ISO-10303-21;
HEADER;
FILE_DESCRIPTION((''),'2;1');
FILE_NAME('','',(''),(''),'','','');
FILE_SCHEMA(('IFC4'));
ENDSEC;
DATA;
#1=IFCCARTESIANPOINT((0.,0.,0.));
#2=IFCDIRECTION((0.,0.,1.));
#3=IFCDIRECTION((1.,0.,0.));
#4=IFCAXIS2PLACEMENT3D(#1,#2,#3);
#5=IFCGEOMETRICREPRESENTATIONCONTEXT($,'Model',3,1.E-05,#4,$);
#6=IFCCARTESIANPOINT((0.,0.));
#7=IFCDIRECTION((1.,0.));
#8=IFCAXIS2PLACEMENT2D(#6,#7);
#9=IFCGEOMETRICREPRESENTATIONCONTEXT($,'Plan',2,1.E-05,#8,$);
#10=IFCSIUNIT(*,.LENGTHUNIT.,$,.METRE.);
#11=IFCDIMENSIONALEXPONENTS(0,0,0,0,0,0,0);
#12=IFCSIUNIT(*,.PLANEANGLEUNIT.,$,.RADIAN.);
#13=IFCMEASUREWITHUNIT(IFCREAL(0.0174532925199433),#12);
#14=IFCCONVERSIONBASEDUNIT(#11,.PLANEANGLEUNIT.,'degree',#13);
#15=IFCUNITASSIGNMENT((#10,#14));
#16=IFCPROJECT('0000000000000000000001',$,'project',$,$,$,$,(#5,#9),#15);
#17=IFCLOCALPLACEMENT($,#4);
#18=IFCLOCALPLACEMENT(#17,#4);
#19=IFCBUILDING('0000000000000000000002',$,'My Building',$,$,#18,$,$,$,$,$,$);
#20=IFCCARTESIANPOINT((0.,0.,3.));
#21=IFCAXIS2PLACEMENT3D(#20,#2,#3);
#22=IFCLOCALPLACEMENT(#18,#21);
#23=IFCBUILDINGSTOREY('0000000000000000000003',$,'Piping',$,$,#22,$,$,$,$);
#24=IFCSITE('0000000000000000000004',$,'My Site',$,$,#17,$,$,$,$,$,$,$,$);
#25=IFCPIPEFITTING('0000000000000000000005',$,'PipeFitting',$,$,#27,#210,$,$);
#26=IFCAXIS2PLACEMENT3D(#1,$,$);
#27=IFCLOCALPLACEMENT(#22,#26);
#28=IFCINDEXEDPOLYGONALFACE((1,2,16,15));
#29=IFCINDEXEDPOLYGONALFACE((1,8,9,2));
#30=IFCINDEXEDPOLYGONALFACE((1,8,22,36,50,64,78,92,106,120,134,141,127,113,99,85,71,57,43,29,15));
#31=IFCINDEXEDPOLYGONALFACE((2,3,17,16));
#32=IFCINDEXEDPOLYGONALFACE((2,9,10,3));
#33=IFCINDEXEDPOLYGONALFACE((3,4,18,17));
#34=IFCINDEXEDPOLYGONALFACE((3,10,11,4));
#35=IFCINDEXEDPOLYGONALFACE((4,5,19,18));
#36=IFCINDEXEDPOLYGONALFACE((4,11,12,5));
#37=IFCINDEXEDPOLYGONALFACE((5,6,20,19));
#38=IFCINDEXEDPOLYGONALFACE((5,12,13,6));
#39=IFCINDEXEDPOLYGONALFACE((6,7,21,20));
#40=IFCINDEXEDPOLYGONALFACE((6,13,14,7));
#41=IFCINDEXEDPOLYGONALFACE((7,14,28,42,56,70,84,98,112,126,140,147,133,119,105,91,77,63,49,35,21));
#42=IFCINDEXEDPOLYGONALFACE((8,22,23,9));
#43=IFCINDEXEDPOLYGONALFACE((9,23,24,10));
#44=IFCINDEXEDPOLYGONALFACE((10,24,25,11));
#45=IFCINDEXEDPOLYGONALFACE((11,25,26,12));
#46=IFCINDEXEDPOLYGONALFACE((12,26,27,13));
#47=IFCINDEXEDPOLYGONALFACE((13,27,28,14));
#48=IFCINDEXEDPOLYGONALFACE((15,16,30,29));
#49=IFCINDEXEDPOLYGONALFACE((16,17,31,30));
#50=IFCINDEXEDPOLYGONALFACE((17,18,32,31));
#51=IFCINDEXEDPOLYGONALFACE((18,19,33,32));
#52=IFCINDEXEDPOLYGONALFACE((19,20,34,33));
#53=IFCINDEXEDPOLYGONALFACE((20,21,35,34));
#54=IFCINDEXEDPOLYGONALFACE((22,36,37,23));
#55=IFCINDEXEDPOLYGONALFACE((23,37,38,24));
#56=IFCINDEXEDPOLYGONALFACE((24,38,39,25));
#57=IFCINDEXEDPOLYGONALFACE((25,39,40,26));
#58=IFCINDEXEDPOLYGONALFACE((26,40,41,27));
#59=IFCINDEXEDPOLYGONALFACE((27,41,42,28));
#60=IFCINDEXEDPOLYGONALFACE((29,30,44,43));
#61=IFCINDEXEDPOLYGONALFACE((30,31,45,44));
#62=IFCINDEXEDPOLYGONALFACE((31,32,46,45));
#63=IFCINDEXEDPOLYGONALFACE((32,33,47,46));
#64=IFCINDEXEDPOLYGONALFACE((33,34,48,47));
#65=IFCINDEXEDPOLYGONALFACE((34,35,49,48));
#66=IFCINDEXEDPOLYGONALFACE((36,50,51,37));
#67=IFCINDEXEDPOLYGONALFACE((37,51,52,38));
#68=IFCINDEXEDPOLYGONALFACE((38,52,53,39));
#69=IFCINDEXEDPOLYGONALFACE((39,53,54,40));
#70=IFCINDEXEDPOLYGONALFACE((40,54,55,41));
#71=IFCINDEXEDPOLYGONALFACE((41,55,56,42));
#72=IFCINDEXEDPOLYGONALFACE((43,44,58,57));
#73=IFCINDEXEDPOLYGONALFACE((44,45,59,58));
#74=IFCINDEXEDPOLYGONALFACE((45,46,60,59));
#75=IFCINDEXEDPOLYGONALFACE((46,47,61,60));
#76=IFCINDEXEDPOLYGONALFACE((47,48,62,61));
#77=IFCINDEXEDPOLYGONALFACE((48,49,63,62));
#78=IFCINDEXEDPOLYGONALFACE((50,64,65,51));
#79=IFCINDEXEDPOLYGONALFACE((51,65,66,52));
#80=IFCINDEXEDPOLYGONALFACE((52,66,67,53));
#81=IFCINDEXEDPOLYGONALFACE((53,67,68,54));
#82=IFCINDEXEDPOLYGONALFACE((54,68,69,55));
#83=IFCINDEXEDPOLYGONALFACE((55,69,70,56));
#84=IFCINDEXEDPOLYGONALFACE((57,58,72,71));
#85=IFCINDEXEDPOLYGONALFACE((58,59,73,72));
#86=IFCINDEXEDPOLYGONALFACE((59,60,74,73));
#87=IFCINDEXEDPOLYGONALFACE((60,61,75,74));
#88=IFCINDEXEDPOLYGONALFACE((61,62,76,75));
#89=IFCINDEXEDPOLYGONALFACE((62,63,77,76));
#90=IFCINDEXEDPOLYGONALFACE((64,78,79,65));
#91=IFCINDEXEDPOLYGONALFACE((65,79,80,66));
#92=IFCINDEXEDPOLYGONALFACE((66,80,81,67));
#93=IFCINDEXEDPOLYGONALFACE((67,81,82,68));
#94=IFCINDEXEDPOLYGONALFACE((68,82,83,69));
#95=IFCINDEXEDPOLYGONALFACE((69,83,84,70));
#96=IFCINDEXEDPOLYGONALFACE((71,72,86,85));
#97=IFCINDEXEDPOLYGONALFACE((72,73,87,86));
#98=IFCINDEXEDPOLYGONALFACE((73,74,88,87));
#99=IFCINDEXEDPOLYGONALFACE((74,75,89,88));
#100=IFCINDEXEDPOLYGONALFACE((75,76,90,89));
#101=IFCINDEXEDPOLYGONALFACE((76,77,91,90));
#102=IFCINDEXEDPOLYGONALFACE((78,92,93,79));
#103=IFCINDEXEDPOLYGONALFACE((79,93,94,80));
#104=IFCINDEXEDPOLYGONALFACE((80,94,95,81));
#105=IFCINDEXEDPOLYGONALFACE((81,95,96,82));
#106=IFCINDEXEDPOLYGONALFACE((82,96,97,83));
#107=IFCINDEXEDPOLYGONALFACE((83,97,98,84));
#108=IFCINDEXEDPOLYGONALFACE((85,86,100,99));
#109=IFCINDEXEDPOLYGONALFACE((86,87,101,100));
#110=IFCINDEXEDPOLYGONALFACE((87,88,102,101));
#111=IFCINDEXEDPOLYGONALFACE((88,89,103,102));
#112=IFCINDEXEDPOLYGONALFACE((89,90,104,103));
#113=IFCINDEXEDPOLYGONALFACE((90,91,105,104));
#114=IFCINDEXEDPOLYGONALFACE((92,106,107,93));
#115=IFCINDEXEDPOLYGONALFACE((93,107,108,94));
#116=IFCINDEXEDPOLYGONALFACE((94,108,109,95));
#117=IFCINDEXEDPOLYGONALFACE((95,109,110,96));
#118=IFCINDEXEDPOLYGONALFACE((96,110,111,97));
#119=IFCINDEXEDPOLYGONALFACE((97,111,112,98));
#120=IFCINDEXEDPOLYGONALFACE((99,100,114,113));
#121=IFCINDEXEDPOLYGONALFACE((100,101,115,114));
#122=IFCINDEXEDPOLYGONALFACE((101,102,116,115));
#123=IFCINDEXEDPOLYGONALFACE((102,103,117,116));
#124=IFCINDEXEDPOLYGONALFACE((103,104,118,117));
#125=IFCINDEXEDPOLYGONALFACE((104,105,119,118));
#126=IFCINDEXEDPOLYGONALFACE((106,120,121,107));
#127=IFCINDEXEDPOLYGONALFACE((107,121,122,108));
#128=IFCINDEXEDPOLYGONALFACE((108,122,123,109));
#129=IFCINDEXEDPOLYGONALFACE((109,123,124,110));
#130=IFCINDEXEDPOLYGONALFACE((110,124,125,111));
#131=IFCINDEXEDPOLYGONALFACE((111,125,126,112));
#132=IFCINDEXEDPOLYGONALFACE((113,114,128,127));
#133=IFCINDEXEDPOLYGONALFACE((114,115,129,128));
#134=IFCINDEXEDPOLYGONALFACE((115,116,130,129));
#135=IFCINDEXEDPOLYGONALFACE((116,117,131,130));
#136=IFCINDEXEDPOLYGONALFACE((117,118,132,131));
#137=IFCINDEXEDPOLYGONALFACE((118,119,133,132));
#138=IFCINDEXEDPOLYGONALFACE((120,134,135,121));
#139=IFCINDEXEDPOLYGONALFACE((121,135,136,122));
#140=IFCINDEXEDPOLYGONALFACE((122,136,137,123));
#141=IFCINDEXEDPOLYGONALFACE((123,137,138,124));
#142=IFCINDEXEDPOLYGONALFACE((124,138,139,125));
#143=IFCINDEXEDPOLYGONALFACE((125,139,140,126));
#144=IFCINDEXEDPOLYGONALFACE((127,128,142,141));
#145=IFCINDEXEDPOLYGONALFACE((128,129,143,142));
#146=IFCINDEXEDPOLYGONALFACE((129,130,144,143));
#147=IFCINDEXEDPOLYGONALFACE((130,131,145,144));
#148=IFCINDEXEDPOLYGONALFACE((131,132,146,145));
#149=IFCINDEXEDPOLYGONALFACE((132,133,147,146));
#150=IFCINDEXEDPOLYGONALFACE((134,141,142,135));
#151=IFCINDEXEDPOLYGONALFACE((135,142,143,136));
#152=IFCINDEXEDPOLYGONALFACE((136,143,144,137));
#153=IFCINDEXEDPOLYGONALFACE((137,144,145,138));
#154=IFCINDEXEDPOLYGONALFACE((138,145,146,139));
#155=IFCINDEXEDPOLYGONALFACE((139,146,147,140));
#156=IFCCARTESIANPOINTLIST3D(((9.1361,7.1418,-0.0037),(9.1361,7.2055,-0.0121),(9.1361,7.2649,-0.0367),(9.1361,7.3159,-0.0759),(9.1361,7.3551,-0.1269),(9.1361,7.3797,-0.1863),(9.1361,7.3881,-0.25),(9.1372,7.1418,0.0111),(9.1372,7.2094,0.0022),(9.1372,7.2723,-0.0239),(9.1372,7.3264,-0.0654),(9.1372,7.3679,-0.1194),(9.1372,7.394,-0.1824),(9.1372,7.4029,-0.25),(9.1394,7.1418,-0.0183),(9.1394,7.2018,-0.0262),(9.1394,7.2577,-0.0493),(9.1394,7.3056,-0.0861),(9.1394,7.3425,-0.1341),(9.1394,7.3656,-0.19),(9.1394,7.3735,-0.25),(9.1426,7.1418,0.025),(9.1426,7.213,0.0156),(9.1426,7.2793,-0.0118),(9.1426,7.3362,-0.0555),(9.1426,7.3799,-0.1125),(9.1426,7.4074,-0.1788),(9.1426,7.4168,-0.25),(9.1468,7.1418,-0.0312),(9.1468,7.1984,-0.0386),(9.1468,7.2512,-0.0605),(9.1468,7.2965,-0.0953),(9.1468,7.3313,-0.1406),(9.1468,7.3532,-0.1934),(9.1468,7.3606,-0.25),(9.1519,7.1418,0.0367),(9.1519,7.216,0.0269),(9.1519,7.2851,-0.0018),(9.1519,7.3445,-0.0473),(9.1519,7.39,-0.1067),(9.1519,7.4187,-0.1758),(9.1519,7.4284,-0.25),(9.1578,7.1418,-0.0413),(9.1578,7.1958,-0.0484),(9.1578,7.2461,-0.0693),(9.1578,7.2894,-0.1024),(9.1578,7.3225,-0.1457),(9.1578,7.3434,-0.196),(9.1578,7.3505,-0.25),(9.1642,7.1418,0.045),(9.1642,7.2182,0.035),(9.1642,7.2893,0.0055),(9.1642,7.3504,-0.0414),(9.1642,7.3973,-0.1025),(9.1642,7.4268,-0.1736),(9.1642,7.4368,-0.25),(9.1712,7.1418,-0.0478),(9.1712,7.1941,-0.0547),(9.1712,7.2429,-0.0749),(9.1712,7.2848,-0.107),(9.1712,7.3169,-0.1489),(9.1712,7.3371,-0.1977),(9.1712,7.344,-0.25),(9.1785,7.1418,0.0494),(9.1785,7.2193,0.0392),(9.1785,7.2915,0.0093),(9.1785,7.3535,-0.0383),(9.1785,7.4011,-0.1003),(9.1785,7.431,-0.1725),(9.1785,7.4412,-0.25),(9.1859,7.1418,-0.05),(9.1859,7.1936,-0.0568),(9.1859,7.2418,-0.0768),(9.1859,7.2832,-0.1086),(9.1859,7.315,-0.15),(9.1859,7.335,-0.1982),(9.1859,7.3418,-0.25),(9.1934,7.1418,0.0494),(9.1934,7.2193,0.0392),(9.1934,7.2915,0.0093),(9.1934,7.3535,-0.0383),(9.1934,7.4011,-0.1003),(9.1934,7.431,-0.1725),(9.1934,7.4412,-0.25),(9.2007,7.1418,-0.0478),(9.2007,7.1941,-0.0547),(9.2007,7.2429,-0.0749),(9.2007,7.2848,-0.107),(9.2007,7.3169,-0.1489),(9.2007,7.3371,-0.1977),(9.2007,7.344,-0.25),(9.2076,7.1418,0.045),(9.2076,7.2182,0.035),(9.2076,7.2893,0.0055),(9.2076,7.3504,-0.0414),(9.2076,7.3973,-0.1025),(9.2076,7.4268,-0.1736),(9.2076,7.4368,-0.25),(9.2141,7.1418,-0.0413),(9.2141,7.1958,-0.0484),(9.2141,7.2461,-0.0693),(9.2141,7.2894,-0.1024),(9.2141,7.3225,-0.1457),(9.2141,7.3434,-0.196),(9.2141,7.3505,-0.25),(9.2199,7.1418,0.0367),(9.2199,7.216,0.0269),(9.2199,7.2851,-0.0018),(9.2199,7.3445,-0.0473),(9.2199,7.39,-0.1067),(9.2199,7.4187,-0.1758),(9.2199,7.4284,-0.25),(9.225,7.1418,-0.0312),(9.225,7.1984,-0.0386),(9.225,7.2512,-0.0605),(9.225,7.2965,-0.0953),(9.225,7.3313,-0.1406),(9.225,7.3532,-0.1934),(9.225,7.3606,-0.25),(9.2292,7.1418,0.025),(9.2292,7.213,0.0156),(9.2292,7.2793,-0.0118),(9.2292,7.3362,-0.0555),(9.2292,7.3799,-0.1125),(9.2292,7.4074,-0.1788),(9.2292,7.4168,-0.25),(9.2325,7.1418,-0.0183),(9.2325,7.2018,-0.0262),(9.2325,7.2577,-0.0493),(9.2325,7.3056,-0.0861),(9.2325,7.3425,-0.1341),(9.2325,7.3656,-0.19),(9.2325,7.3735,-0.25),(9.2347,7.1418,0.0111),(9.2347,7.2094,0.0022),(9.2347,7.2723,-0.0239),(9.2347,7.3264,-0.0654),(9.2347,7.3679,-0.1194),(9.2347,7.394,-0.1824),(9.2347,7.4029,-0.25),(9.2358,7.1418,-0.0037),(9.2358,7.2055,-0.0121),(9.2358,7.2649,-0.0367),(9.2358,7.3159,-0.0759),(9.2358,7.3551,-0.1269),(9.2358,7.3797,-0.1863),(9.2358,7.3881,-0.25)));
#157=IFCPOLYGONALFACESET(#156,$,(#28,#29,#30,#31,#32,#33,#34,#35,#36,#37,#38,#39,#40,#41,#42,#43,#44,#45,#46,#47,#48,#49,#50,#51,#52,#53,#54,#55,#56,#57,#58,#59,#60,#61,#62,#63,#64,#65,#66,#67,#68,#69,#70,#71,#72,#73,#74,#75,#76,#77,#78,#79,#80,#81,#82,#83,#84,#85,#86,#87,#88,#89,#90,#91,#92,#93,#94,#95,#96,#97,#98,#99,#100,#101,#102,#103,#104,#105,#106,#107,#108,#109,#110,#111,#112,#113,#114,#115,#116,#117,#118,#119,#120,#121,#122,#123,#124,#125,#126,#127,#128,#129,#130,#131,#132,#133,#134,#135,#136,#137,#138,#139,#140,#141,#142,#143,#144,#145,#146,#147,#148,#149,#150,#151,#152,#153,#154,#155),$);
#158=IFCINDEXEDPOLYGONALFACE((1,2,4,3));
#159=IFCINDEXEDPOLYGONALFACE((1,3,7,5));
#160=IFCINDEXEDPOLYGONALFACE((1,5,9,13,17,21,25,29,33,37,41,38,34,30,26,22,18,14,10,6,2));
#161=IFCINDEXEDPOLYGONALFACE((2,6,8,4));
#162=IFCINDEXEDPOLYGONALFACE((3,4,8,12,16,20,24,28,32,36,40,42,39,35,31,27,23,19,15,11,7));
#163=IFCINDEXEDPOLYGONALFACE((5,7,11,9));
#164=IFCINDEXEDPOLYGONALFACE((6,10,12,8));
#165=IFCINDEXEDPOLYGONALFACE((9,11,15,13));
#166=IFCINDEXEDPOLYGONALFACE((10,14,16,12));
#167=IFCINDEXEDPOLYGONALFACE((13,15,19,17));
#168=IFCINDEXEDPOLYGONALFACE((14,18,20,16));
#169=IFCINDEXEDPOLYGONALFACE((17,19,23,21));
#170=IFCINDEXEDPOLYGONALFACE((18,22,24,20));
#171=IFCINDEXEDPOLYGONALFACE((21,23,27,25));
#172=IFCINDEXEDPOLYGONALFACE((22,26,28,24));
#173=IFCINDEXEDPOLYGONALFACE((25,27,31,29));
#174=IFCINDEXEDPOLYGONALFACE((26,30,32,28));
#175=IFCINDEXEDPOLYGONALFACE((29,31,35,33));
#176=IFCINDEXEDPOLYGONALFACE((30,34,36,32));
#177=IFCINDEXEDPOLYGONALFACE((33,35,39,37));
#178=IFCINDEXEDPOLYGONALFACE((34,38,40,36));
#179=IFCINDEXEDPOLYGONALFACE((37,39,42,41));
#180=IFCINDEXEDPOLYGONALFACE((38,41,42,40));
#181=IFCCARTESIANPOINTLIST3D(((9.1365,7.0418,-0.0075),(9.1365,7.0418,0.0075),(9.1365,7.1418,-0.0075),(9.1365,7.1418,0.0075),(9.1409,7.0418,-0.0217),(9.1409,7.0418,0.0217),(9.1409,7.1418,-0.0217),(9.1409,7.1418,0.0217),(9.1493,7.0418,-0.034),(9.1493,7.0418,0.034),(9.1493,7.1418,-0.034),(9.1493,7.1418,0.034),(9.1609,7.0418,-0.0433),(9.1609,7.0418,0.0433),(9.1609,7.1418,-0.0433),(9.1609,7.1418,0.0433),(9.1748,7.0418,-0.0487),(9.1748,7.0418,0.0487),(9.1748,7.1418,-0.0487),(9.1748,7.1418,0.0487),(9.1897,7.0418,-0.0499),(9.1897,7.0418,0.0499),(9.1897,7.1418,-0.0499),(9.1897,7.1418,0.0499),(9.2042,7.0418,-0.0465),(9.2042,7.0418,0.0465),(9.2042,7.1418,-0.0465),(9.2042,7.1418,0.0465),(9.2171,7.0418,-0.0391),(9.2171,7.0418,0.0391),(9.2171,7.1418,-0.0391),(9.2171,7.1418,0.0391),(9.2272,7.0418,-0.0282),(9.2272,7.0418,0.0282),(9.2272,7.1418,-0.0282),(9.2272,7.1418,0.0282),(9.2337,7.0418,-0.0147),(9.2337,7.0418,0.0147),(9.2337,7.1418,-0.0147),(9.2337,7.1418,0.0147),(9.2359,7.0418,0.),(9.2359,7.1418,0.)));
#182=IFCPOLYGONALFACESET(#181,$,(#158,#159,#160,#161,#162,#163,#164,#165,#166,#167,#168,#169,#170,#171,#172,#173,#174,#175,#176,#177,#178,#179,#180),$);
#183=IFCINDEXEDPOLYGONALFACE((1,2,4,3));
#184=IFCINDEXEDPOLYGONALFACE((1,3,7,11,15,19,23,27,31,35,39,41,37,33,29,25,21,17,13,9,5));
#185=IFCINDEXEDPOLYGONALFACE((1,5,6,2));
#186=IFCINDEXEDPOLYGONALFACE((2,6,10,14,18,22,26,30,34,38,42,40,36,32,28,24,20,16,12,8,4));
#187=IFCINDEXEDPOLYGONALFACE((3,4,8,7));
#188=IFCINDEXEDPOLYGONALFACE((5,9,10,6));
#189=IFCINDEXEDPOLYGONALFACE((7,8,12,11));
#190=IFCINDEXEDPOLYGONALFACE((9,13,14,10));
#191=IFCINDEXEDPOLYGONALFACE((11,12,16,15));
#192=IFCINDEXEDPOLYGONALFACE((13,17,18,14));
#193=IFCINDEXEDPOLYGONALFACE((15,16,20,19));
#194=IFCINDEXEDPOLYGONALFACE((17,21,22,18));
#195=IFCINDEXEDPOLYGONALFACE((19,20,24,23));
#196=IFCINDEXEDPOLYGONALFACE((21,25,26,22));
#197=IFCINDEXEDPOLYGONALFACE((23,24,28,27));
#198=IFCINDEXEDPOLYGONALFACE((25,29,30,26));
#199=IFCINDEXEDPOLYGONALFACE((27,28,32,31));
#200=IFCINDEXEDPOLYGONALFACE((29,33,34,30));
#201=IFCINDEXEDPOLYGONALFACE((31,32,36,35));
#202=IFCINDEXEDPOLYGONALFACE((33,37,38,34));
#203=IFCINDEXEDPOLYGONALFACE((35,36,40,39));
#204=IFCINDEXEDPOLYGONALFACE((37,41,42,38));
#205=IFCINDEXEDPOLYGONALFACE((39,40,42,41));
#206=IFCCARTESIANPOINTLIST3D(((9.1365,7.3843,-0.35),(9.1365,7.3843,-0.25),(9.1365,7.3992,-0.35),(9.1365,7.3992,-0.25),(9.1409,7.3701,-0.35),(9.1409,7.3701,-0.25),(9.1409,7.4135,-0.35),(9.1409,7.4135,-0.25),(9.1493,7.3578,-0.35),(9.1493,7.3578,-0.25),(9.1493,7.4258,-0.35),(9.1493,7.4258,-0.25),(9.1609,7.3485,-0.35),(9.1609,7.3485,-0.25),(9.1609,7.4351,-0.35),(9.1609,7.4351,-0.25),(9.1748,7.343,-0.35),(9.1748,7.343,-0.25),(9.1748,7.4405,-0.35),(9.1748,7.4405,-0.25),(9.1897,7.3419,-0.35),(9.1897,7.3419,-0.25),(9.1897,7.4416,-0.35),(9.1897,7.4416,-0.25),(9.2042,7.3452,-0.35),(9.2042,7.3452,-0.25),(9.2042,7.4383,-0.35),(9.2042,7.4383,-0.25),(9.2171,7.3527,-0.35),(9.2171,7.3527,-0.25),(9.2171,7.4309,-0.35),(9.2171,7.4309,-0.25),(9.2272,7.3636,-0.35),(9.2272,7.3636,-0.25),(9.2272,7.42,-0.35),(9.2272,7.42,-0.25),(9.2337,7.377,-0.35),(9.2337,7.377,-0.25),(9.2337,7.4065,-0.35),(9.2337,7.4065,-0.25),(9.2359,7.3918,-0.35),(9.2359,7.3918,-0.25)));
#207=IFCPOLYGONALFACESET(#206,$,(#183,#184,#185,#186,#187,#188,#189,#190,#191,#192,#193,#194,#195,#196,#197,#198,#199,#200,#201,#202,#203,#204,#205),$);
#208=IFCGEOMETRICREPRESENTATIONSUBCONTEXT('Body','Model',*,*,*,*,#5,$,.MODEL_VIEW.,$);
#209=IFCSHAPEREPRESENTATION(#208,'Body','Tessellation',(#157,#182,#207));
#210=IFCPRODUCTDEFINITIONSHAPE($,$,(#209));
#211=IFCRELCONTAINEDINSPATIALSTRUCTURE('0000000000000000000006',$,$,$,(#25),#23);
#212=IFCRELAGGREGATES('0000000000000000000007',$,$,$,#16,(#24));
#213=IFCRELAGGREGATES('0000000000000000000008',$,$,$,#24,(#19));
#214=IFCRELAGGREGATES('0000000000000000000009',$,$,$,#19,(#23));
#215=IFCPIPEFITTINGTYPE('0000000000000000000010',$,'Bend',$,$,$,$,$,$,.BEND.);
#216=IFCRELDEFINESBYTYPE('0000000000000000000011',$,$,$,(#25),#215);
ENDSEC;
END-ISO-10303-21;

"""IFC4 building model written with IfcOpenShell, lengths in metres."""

from ifc_helpers import new_model, entity, si_unit, converted_unit, frame, origin_with_axes, origin_2d_with_axis, place, context, subcontext, project, spatial, circle, extrude, source, transform, mapped, type_object, type_shapes, element, save


model = new_model("IFC4")

# Units and contexts
model_context = context("Model", 3, precision=1e-05, world=origin_with_axes())
plan_context = context("Plan", 2, precision=1e-05, world=origin_2d_with_axis())
body_context = subcontext(model_context, "Body", "Model", "MODEL_VIEW")
ifc_project = project(units=[si_unit("LENGTHUNIT", "METRE"), converted_unit("PLANEANGLEUNIT", "degree", entity("IfcReal", 0.0174532925199433), si_unit("PLANEANGLEUNIT", "RADIAN"), dimensions=[0, 0, 0, 0, 0, 0, 0])], contexts=[model_context, plan_context])

# Site, building, storey
site_placement = place(None, origin_with_axes())
site = spatial("IfcSite", under=ifc_project, at=site_placement, Name="My Site")
building_placement = place(site_placement, origin_with_axes())
building = spatial("IfcBuilding", under=site, at=building_placement, Name="My Building")
storey_placement = place(building_placement, frame((0.0, 0.0, 3.0), z_axis=(0.0, 0.0, 1.0), x_axis=(1.0, 0.0, 0.0)))
storey = spatial("IfcBuildingStorey", under=building, at=storey_placement, Name="Piping")

# Pipe fitting
pipe_fitting_type = type_object("IfcPipeFittingType", Name="Bend", PredefinedType="BEND")
shared_shape = source(origin_with_axes(), body_context, "Body", "SolidModel", [
    entity("IfcSweptDiskSolid", entity("IfcIndexedPolyCurve", entity("IfcCartesianPointList3D", [[0.0, 0.0, -0.1], [0.0, -0.0732, -0.2768], [0.0, -0.25, -0.35]]), [entity("IfcArcIndex", [1, 2, 3])]), 0.05),
    extrude(circle(Radius=0.05), origin_with_axes(), (0.0, 0.0, -1.0), 0.1),
    extrude(circle(Radius=0.05), frame((0.0, -0.25, -0.35), z_axis=(0.0, -1.0, 0.0), x_axis=(1.0, 0.0, 0.0)), (0.0, 0.0, 1.0), 0.1),
])
type_shapes(pipe_fitting_type, [shared_shape])
for number, where, z_axis, x_axis, name in (
    (1, (9.1859, 7.0418, 0.0), (0.0, -1.0, 0.0), (1.0, 0.0, 0.0), "PipeFitting"),
):
    element("IfcPipeFitting", number, at=place(storey_placement, frame(where, z_axis=z_axis, x_axis=x_axis)), inside=storey, type_object=pipe_fitting_type, Name=name, context=body_context, shape_type="MappedRepresentation", body=[
        mapped(shared_shape, transform((0.0, 0.0, 0.0), x_axis=(1.0, 0.0, 0.0), y_axis=(0.0, 1.0, 0.0), z_axis=(0.0, 0.0, 1.0), scale=1.0)),
    ])

save(model, "model.ifc")
